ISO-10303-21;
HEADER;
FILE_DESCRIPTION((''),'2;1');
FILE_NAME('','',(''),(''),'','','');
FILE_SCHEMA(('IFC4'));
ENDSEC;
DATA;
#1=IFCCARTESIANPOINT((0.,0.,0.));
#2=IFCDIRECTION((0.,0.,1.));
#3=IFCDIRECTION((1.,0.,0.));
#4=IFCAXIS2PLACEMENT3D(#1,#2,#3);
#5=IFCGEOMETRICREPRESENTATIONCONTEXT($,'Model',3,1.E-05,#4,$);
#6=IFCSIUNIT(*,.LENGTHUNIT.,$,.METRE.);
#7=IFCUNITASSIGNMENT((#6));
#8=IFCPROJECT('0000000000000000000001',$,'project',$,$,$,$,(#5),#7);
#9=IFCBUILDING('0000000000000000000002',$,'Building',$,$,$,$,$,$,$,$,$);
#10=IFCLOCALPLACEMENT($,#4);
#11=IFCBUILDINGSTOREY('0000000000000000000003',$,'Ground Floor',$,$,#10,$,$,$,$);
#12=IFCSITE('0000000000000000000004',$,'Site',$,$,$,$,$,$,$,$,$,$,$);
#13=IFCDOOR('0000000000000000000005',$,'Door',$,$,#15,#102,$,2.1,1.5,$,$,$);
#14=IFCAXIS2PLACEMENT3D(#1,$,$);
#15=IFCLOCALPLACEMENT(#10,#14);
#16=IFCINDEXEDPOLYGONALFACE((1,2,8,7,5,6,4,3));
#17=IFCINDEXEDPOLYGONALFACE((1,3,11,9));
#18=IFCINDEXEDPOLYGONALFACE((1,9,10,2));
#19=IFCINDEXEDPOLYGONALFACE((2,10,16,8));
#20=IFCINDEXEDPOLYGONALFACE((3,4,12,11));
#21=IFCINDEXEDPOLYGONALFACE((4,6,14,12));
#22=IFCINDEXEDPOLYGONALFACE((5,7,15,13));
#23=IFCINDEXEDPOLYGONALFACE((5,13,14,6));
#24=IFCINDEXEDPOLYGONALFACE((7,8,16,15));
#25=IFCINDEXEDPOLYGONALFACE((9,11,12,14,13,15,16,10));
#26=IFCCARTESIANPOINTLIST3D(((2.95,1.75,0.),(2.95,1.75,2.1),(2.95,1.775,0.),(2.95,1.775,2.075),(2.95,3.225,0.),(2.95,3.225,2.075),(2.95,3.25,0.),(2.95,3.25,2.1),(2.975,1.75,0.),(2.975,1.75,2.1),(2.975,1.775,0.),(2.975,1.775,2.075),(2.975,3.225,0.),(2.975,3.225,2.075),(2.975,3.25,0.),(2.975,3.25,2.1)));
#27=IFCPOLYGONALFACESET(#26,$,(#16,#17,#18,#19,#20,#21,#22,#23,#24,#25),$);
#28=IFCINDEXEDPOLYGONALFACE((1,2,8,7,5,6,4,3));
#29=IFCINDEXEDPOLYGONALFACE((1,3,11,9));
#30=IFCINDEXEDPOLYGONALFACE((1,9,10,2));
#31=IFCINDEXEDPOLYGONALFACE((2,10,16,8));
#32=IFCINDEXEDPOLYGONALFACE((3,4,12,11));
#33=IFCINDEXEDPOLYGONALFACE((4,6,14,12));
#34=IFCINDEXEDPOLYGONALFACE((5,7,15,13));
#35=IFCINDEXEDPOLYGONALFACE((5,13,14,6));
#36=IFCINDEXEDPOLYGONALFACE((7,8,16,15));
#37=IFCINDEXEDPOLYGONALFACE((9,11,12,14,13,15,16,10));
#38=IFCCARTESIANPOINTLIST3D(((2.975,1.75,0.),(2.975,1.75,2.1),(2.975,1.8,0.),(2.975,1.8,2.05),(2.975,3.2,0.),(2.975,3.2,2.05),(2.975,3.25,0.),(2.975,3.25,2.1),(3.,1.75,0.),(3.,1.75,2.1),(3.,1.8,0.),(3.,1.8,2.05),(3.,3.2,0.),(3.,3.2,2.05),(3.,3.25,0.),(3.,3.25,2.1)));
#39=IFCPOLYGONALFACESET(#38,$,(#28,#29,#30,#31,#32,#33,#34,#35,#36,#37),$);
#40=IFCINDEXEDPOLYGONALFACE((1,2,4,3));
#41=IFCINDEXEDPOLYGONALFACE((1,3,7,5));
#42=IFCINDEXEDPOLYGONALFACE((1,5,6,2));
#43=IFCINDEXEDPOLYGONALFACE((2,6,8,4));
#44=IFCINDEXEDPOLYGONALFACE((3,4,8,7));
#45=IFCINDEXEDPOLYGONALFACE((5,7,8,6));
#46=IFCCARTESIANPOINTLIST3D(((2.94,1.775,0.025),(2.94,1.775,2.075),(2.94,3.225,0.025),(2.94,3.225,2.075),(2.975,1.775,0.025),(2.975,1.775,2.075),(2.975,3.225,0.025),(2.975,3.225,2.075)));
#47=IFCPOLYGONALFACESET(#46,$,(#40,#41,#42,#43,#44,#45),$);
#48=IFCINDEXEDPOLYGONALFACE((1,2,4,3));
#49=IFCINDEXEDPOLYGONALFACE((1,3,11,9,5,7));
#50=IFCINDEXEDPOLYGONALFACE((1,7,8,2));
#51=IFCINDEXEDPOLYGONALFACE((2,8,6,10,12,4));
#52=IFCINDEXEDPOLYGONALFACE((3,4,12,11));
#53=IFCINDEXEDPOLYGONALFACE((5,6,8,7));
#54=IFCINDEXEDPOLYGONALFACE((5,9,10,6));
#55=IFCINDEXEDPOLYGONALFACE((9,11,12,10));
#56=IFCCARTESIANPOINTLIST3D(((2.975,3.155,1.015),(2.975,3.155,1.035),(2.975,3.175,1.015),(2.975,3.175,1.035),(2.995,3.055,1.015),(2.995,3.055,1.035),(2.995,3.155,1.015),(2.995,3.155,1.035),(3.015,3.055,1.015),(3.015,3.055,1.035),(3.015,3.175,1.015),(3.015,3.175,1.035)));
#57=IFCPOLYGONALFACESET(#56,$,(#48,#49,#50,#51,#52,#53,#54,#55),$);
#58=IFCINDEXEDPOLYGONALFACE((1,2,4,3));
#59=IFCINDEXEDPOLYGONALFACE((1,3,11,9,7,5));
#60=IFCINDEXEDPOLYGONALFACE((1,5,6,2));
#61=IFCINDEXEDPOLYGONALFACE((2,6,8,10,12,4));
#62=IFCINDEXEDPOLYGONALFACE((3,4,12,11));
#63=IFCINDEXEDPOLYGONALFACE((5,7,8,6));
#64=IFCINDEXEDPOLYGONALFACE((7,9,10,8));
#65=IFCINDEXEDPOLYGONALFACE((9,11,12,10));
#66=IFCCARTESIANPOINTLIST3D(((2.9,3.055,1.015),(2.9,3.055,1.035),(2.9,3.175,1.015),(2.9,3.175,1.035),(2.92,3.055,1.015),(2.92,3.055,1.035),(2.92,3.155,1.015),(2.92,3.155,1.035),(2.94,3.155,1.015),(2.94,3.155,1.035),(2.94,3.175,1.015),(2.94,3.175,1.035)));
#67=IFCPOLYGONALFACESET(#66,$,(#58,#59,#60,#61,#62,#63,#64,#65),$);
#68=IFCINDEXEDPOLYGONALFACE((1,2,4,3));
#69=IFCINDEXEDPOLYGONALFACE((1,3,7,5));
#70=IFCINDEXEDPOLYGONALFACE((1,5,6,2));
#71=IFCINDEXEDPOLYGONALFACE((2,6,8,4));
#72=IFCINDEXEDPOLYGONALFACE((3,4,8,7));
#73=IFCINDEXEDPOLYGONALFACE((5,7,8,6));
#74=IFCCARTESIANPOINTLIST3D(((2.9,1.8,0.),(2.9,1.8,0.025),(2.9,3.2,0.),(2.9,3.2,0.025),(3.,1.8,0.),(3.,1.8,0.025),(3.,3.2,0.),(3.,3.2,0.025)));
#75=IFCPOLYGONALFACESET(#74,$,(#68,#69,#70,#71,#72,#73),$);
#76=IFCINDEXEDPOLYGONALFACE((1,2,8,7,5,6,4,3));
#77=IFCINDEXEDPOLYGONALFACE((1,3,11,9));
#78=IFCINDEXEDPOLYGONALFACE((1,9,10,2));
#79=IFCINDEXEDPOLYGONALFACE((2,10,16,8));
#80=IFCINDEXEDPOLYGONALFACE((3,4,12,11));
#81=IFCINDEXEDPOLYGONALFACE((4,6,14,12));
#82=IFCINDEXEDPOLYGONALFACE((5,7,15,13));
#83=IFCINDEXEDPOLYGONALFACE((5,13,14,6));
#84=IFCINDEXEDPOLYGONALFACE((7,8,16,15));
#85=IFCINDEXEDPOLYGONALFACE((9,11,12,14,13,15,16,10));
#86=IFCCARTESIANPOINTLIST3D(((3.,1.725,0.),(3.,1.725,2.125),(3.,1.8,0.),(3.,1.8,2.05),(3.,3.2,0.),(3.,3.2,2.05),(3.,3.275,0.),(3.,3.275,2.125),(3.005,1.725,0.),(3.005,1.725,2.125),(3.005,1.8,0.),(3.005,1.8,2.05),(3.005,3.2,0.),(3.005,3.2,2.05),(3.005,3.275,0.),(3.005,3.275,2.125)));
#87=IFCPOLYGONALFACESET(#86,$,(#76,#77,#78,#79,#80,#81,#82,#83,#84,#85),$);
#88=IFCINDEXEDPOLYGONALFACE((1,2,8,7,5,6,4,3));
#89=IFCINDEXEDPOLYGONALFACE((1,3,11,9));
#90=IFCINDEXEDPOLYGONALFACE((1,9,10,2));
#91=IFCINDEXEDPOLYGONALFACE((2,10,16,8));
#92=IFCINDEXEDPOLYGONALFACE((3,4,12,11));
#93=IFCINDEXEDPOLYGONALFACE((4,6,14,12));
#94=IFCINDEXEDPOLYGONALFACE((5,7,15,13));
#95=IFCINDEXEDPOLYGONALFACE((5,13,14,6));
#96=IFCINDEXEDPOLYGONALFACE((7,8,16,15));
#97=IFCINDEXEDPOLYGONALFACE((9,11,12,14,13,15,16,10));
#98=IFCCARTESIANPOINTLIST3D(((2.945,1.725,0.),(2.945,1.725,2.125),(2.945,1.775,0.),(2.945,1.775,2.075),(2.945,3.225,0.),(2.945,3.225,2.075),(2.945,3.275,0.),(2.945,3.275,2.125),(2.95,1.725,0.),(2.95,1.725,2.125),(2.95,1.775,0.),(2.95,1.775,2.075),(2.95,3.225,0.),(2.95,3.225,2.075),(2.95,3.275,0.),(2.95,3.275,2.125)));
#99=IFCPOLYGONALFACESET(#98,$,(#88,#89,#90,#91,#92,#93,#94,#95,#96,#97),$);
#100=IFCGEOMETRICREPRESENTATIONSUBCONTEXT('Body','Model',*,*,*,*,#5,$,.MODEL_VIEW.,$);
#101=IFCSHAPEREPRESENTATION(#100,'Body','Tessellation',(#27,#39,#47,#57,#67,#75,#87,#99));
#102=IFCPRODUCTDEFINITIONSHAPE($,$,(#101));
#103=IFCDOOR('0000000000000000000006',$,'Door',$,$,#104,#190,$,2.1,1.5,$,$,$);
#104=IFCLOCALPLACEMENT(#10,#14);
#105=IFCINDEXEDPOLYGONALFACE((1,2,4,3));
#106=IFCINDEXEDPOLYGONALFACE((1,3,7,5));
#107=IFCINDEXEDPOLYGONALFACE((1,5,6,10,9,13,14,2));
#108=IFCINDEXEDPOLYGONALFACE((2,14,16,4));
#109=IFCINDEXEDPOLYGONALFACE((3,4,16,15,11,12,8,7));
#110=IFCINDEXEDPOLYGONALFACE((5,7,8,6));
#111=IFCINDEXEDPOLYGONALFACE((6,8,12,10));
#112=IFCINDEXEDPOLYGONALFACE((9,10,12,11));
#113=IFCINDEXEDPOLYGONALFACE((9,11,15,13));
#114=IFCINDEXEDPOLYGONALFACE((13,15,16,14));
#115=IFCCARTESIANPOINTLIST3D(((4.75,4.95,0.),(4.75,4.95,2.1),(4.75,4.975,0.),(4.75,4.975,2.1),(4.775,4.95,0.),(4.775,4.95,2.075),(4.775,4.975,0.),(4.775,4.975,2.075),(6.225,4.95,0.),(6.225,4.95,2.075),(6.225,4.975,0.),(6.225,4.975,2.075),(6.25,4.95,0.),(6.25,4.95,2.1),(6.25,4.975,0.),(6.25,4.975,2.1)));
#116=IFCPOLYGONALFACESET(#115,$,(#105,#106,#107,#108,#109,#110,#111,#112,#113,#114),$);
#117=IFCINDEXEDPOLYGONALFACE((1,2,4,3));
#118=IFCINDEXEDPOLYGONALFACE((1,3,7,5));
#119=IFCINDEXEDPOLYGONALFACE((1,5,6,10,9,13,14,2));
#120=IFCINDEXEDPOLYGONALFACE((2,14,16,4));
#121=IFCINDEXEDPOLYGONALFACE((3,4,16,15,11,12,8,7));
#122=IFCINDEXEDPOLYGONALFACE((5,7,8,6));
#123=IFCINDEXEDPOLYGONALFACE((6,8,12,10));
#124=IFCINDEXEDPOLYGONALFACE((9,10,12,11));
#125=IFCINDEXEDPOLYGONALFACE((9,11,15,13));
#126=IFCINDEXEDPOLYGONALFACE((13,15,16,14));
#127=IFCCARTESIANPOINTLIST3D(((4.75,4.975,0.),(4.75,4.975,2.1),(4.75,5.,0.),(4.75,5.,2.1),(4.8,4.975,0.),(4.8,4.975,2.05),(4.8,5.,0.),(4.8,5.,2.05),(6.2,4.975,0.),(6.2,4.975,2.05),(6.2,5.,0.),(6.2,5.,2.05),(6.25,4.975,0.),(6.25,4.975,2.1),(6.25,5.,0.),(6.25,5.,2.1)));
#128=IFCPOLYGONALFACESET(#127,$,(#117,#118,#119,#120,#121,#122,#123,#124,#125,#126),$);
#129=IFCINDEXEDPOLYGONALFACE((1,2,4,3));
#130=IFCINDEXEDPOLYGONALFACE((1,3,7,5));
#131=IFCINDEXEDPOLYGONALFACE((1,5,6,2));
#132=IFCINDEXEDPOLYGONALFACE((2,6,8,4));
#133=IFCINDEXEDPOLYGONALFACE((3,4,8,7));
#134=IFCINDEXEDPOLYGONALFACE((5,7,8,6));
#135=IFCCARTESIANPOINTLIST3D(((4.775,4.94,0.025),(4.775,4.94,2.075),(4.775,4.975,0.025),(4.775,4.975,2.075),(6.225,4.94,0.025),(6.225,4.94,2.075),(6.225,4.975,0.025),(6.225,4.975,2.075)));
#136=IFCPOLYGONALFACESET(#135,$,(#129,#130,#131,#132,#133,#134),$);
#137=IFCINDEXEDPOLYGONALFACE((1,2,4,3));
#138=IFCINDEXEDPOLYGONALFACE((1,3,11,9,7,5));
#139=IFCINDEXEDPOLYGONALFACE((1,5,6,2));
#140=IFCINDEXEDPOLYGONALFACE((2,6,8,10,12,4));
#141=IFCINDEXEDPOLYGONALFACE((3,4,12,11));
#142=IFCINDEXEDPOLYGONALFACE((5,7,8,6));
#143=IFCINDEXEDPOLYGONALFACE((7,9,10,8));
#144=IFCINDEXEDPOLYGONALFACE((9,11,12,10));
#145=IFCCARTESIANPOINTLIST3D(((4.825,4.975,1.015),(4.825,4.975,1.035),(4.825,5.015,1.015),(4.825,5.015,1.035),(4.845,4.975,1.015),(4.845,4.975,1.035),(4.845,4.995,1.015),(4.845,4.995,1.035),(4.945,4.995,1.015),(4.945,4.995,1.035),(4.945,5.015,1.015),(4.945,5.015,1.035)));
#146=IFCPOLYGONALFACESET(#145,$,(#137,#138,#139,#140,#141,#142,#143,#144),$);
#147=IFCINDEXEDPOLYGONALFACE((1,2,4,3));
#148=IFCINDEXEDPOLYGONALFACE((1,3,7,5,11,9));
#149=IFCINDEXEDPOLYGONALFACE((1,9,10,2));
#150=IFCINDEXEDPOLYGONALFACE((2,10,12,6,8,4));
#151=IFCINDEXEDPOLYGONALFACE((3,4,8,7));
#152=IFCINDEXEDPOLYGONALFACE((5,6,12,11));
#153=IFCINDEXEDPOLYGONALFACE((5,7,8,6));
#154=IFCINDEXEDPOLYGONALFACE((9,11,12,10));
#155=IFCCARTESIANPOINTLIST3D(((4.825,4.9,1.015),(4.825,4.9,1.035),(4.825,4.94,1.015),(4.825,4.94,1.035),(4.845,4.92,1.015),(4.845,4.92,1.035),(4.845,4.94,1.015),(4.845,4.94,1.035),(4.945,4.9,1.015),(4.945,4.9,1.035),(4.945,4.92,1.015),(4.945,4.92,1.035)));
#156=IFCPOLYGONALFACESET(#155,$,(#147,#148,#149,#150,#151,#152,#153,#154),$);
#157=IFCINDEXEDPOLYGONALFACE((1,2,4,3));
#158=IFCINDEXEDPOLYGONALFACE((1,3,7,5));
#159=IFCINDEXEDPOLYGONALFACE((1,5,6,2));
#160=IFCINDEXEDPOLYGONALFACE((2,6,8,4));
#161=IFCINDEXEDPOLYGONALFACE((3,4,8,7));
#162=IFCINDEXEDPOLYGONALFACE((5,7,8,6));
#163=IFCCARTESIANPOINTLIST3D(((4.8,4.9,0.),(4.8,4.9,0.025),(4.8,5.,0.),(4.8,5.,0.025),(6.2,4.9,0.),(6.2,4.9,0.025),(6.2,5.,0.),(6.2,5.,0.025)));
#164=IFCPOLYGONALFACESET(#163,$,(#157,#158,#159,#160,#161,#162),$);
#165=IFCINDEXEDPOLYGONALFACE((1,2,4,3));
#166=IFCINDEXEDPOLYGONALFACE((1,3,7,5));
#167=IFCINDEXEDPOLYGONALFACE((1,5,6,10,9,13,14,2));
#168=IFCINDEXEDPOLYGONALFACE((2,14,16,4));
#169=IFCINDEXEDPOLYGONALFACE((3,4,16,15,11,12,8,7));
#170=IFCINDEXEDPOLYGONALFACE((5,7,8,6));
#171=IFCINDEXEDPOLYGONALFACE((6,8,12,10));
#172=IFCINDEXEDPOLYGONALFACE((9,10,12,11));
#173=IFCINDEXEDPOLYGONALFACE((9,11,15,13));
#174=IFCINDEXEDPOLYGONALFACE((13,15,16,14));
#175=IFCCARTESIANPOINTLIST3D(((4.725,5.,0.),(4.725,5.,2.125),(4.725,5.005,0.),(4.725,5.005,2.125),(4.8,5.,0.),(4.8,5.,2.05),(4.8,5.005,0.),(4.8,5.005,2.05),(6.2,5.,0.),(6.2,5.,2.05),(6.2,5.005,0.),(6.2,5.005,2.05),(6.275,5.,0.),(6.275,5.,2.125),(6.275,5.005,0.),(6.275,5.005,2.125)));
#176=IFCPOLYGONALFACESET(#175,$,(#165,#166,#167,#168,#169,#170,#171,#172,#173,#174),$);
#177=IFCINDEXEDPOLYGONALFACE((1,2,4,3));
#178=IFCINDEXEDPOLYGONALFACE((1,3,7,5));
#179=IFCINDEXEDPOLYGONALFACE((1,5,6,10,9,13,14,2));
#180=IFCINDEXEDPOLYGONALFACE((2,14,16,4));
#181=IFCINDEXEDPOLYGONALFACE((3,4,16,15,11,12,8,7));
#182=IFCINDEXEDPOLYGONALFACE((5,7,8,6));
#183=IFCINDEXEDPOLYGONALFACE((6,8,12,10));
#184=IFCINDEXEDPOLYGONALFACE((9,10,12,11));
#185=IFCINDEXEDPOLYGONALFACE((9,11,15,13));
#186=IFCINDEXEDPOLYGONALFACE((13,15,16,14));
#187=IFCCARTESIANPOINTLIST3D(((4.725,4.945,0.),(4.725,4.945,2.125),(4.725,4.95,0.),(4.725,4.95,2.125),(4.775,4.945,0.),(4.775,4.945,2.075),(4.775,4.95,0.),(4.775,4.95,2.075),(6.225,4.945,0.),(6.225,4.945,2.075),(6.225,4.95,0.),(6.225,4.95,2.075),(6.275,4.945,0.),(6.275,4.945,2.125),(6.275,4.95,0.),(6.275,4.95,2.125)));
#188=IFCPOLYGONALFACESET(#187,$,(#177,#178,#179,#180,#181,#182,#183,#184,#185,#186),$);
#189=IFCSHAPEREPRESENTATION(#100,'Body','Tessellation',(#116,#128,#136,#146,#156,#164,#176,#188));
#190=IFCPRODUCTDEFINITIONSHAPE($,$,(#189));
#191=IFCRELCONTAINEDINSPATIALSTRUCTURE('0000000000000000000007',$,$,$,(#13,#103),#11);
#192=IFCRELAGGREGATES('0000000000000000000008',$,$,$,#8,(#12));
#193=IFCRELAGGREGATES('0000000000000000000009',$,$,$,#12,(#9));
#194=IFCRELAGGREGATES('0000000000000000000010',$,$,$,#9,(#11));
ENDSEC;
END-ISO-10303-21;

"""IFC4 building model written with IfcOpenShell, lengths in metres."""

from ifc_helpers import new_model, si_unit, frame, origin_with_axes, place, context, subcontext, project, spatial, line, indexed_curve, outline, extrude, element, save


model = new_model("IFC4")

# Units and contexts
model_context = context("Model", 3, precision=1e-05, world=origin_with_axes())
body_context = subcontext(model_context, "Body", "Model", "MODEL_VIEW")
ifc_project = project(units=[si_unit("LENGTHUNIT", "METRE")], contexts=[model_context])

# Site, building, storey
site = spatial("IfcSite", under=ifc_project, Name="Site")
building = spatial("IfcBuilding", under=site, Name="Building")
storey_placement = place(None, origin_with_axes())
storey = spatial("IfcBuildingStorey", under=building, at=storey_placement, Name="Ground Floor")

# Doors
door_1_placement = place(storey_placement, frame((3.0, 1.75, 0.0), z_axis=(0.0, 0.0, 1.0), x_axis=(0.0, 1.0, 0.0)))
element("IfcDoor", 1, at=door_1_placement, inside=storey, Name="Door", OverallHeight=2.1, OverallWidth=1.5, context=body_context, shape_type="SweptSolid", body=[
    extrude(outline(indexed_curve([(0.0, 0.0), (0.0, 2.1), (1.5, 2.1), (1.5, 0.0), (1.475, 0.0), (1.475, 2.075), (0.025, 2.075), (0.025, 0.0)], segments=[line(1, 2, 3, 4, 5, 6, 7, 8, 1)])), frame((0.0, 0.025, 0.0), z_axis=(0.0, -1.0, 0.0), x_axis=(1.0, 0.0, 0.0)), (0.0, 0.0, -1.0), 0.025),
    extrude(outline(indexed_curve([(0.0, 0.0), (0.0, 2.1), (1.5, 2.1), (1.5, 0.0), (1.45, 0.0), (1.45, 2.05), (0.05, 2.05), (0.05, 0.0)], segments=[line(1, 2, 3, 4, 5, 6, 7, 8, 1)])), frame((0.0, 0.0, 0.0), z_axis=(0.0, -1.0, 0.0), x_axis=(1.0, 0.0, 0.0)), (0.0, 0.0, -1.0), 0.025),
    extrude(outline(indexed_curve([(0.0, 0.0), (1.45, 0.0), (1.45, 0.035), (0.0, 0.035)], segments=[line(1, 2, 3, 4, 1)])), frame((0.025, 0.025, 0.025), z_axis=(0.0, 0.0, 1.0), x_axis=(1.0, 0.0, 0.0)), (0.0, 0.0, 1.0), 2.05),
    extrude(outline(indexed_curve([(0.0, 0.0), (0.0, -0.04), (-0.12, -0.04), (-0.12, -0.02), (-0.02, -0.02), (-0.02, 0.0)], segments=[line(1, 2, 3, 4, 5, 6, 1)])), frame((1.425, 0.025, 1.015), z_axis=(0.0, 0.0, 1.0), x_axis=(1.0, 0.0, 0.0)), (0.0, 0.0, 1.0), 0.02),
    extrude(outline(indexed_curve([(0.0, 0.0), (0.0, 0.04), (-0.12, 0.04), (-0.12, 0.02), (-0.02, 0.02), (-0.02, 0.0)], segments=[line(1, 2, 3, 4, 5, 6, 1)])), frame((1.425, 0.06, 1.015), z_axis=(0.0, 0.0, 1.0), x_axis=(1.0, 0.0, 0.0)), (0.0, 0.0, 1.0), 0.02),
    extrude(outline(indexed_curve([(0.0, 0.0), (1.4, 0.0), (1.4, 0.1), (0.0, 0.1)], segments=[line(1, 2, 3, 4, 1)])), frame((0.05, 0.0, 0.0), z_axis=(0.0, 0.0, 1.0), x_axis=(1.0, 0.0, 0.0)), (0.0, 0.0, 1.0), 0.025),
    extrude(outline(indexed_curve([(0.0, 0.0), (0.0, 2.125), (1.55, 2.125), (1.55, 0.0), (1.475, 0.0), (1.475, 2.05), (0.075, 2.05), (0.075, 0.0)], segments=[line(1, 2, 3, 4, 5, 6, 7, 8, 1)])), frame((-0.025, -0.005, 0.0), z_axis=(0.0, -1.0, 0.0), x_axis=(1.0, 0.0, 0.0)), (0.0, 0.0, -1.0), 0.005),
    extrude(outline(indexed_curve([(0.0, 0.0), (0.0, 2.125), (1.55, 2.125), (1.55, 0.0), (1.5, 0.0), (1.5, 2.075), (0.05, 2.075), (0.05, 0.0)], segments=[line(1, 2, 3, 4, 5, 6, 7, 8, 1)])), frame((-0.025, 0.05, 0.0), z_axis=(0.0, -1.0, 0.0), x_axis=(1.0, 0.0, 0.0)), (0.0, 0.0, -1.0), 0.005),
])
door_2_placement = place(storey_placement, frame((6.25, 5.0, 0.0), z_axis=(0.0, 0.0, 1.0), x_axis=(-1.0, 0.0, 0.0)))
element("IfcDoor", 2, at=door_2_placement, inside=storey, Name="Door", OverallHeight=2.1, OverallWidth=1.5, context=body_context, shape_type="SweptSolid", body=[
    extrude(outline(indexed_curve([(0.0, 0.0), (0.0, 2.1), (1.5, 2.1), (1.5, 0.0), (1.475, 0.0), (1.475, 2.075), (0.025, 2.075), (0.025, 0.0)], segments=[line(1, 2, 3, 4, 5, 6, 7, 8, 1)])), frame((0.0, 0.025, 0.0), z_axis=(0.0, -1.0, 0.0), x_axis=(1.0, 0.0, 0.0)), (0.0, 0.0, -1.0), 0.025),
    extrude(outline(indexed_curve([(0.0, 0.0), (0.0, 2.1), (1.5, 2.1), (1.5, 0.0), (1.45, 0.0), (1.45, 2.05), (0.05, 2.05), (0.05, 0.0)], segments=[line(1, 2, 3, 4, 5, 6, 7, 8, 1)])), frame((0.0, 0.0, 0.0), z_axis=(0.0, -1.0, 0.0), x_axis=(1.0, 0.0, 0.0)), (0.0, 0.0, -1.0), 0.025),
    extrude(outline(indexed_curve([(0.0, 0.0), (1.45, 0.0), (1.45, 0.035), (0.0, 0.035)], segments=[line(1, 2, 3, 4, 1)])), frame((0.025, 0.025, 0.025), z_axis=(0.0, 0.0, 1.0), x_axis=(1.0, 0.0, 0.0)), (0.0, 0.0, 1.0), 2.05),
    extrude(outline(indexed_curve([(0.0, 0.0), (0.0, -0.04), (-0.12, -0.04), (-0.12, -0.02), (-0.02, -0.02), (-0.02, 0.0)], segments=[line(1, 2, 3, 4, 5, 6, 1)])), frame((1.425, 0.025, 1.015), z_axis=(0.0, 0.0, 1.0), x_axis=(1.0, 0.0, 0.0)), (0.0, 0.0, 1.0), 0.02),
    extrude(outline(indexed_curve([(0.0, 0.0), (0.0, 0.04), (-0.12, 0.04), (-0.12, 0.02), (-0.02, 0.02), (-0.02, 0.0)], segments=[line(1, 2, 3, 4, 5, 6, 1)])), frame((1.425, 0.06, 1.015), z_axis=(0.0, 0.0, 1.0), x_axis=(1.0, 0.0, 0.0)), (0.0, 0.0, 1.0), 0.02),
    extrude(outline(indexed_curve([(0.0, 0.0), (1.4, 0.0), (1.4, 0.1), (0.0, 0.1)], segments=[line(1, 2, 3, 4, 1)])), frame((0.05, 0.0, 0.0), z_axis=(0.0, 0.0, 1.0), x_axis=(1.0, 0.0, 0.0)), (0.0, 0.0, 1.0), 0.025),
    extrude(outline(indexed_curve([(0.0, 0.0), (0.0, 2.125), (1.55, 2.125), (1.55, 0.0), (1.475, 0.0), (1.475, 2.05), (0.075, 2.05), (0.075, 0.0)], segments=[line(1, 2, 3, 4, 5, 6, 7, 8, 1)])), frame((-0.025, -0.005, 0.0), z_axis=(0.0, -1.0, 0.0), x_axis=(1.0, 0.0, 0.0)), (0.0, 0.0, -1.0), 0.005),
    extrude(outline(indexed_curve([(0.0, 0.0), (0.0, 2.125), (1.55, 2.125), (1.55, 0.0), (1.5, 0.0), (1.5, 2.075), (0.05, 2.075), (0.05, 0.0)], segments=[line(1, 2, 3, 4, 5, 6, 7, 8, 1)])), frame((-0.025, 0.05, 0.0), z_axis=(0.0, -1.0, 0.0), x_axis=(1.0, 0.0, 0.0)), (0.0, 0.0, -1.0), 0.005),
])

save(model, "model.ifc")
